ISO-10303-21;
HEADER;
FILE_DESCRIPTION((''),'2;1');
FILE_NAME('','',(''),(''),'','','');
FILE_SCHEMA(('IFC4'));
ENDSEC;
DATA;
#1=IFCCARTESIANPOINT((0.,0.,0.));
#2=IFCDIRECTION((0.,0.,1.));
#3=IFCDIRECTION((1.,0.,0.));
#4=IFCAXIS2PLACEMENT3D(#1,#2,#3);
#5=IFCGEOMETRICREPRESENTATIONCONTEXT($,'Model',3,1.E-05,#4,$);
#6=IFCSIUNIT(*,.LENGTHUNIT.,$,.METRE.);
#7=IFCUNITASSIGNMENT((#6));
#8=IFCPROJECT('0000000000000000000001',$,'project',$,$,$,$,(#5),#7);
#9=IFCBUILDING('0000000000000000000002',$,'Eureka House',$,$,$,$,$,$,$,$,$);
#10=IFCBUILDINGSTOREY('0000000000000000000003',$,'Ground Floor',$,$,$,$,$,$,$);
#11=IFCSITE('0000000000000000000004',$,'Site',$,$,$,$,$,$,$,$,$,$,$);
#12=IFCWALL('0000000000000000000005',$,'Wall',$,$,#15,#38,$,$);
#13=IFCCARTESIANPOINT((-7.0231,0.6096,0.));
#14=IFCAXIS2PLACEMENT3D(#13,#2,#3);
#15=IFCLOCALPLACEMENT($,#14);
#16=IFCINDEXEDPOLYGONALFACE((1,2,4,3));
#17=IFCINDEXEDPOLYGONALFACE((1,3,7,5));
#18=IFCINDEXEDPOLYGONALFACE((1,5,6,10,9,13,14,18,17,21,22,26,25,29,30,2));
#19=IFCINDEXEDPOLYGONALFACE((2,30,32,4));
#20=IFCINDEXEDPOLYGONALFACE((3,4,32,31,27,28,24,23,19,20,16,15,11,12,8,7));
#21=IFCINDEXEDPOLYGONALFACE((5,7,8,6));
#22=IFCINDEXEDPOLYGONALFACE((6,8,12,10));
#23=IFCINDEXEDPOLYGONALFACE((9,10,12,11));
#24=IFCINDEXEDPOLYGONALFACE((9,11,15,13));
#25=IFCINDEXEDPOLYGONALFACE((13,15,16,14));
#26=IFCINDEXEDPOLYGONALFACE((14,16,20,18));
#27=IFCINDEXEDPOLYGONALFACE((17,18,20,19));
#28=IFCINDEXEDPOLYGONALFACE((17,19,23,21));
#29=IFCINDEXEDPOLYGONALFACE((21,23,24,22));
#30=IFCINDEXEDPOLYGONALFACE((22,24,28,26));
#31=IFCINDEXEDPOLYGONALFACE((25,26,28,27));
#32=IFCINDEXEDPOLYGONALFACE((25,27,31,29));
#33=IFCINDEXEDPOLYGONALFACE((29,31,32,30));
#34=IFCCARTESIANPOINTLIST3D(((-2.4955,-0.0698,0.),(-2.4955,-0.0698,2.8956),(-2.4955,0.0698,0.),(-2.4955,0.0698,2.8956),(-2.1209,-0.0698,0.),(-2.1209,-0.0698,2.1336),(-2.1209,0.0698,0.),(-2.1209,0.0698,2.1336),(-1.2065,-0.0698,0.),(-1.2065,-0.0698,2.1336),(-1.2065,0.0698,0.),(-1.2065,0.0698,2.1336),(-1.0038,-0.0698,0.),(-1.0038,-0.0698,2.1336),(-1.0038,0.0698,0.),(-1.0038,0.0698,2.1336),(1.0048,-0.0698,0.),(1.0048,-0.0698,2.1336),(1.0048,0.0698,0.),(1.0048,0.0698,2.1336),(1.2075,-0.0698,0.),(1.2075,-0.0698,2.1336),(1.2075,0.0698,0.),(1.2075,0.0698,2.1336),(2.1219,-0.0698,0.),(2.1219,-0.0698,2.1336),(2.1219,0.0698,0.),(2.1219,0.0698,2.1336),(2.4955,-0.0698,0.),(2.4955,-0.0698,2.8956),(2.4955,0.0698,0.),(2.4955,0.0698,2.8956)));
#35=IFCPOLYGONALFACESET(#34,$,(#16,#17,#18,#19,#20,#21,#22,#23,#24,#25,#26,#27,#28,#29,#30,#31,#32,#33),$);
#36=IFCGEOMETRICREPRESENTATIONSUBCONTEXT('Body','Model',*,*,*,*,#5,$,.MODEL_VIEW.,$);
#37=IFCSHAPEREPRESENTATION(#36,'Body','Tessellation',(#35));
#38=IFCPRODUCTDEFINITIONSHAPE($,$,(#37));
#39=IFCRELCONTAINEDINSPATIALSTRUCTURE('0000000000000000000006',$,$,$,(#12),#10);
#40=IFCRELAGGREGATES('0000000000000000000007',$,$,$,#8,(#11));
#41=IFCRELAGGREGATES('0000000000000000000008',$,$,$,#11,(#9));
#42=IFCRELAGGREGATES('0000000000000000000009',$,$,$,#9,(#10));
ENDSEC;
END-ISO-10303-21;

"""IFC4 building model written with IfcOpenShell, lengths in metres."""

from ifc_helpers import new_model, si_unit, frame, origin, origin_with_axes, origin_2d, place, context, subcontext, project, spatial, rectangle, extrude, element, save


model = new_model("IFC4")

# Units and contexts
model_context = context("Model", 3, precision=1e-05, world=origin_with_axes())
body_context = subcontext(model_context, "Body", "Model", "MODEL_VIEW")
ifc_project = project(units=[si_unit("LENGTHUNIT", "METRE")], contexts=[model_context])

# Site, building, storey
site = spatial("IfcSite", under=ifc_project, Name="Site")
building = spatial("IfcBuilding", under=site, Name="Eureka House")
storey = spatial("IfcBuildingStorey", under=building, Name="Ground Floor")

# Wall, openings
wall_1_placement = place(None, frame((-7.0231, 0.6096, 0.0), z_axis=(0.0, 0.0, 1.0), x_axis=(1.0, 0.0, 0.0)))
wall_1 = element("IfcWall", 1, at=wall_1_placement, inside=storey, Name="Wall", context=body_context, shape_type="SweptSolid", body=[
    extrude(rectangle(XDim=4.9911, YDim=0.1397, at=origin_2d()), origin(), (0.0, 0.0, 1.0), 2.8956),
])
opening_1_placement = place(wall_1_placement, frame((1.6647, 0.0, 0.0), z_axis=(0.0, 0.0, 1.0), x_axis=(1.0, 0.0, 0.0)))
element("IfcOpeningElement", 2, at=opening_1_placement, cuts=wall_1, context=body_context, shape_type="SweptSolid", body=[
    extrude(rectangle(XDim=0.9144, YDim=0.2397, at=origin_2d()), origin(), (0.0, 0.0, 1.0), 2.1336),
])
opening_2_placement = place(wall_1_placement, frame((-1.6637, 0.0, 0.0), z_axis=(0.0, 0.0, 1.0), x_axis=(1.0, 0.0, 0.0)))
element("IfcOpeningElement", 3, at=opening_2_placement, cuts=wall_1, context=body_context, shape_type="SweptSolid", body=[
    extrude(rectangle(XDim=0.9144, YDim=0.2397, at=origin_2d()), origin(), (0.0, 0.0, 1.0), 2.1336),
])
opening_3_placement = place(wall_1_placement, frame((0.0005, 0.0, 0.0), z_axis=(0.0, 0.0, 1.0), x_axis=(1.0, 0.0, 0.0)))
element("IfcOpeningElement", 4, at=opening_3_placement, cuts=wall_1, context=body_context, shape_type="SweptSolid", body=[
    extrude(rectangle(XDim=2.0086, YDim=0.2397, at=origin_2d()), origin(), (0.0, 0.0, 1.0), 2.1336),
])

save(model, "model.ifc")
